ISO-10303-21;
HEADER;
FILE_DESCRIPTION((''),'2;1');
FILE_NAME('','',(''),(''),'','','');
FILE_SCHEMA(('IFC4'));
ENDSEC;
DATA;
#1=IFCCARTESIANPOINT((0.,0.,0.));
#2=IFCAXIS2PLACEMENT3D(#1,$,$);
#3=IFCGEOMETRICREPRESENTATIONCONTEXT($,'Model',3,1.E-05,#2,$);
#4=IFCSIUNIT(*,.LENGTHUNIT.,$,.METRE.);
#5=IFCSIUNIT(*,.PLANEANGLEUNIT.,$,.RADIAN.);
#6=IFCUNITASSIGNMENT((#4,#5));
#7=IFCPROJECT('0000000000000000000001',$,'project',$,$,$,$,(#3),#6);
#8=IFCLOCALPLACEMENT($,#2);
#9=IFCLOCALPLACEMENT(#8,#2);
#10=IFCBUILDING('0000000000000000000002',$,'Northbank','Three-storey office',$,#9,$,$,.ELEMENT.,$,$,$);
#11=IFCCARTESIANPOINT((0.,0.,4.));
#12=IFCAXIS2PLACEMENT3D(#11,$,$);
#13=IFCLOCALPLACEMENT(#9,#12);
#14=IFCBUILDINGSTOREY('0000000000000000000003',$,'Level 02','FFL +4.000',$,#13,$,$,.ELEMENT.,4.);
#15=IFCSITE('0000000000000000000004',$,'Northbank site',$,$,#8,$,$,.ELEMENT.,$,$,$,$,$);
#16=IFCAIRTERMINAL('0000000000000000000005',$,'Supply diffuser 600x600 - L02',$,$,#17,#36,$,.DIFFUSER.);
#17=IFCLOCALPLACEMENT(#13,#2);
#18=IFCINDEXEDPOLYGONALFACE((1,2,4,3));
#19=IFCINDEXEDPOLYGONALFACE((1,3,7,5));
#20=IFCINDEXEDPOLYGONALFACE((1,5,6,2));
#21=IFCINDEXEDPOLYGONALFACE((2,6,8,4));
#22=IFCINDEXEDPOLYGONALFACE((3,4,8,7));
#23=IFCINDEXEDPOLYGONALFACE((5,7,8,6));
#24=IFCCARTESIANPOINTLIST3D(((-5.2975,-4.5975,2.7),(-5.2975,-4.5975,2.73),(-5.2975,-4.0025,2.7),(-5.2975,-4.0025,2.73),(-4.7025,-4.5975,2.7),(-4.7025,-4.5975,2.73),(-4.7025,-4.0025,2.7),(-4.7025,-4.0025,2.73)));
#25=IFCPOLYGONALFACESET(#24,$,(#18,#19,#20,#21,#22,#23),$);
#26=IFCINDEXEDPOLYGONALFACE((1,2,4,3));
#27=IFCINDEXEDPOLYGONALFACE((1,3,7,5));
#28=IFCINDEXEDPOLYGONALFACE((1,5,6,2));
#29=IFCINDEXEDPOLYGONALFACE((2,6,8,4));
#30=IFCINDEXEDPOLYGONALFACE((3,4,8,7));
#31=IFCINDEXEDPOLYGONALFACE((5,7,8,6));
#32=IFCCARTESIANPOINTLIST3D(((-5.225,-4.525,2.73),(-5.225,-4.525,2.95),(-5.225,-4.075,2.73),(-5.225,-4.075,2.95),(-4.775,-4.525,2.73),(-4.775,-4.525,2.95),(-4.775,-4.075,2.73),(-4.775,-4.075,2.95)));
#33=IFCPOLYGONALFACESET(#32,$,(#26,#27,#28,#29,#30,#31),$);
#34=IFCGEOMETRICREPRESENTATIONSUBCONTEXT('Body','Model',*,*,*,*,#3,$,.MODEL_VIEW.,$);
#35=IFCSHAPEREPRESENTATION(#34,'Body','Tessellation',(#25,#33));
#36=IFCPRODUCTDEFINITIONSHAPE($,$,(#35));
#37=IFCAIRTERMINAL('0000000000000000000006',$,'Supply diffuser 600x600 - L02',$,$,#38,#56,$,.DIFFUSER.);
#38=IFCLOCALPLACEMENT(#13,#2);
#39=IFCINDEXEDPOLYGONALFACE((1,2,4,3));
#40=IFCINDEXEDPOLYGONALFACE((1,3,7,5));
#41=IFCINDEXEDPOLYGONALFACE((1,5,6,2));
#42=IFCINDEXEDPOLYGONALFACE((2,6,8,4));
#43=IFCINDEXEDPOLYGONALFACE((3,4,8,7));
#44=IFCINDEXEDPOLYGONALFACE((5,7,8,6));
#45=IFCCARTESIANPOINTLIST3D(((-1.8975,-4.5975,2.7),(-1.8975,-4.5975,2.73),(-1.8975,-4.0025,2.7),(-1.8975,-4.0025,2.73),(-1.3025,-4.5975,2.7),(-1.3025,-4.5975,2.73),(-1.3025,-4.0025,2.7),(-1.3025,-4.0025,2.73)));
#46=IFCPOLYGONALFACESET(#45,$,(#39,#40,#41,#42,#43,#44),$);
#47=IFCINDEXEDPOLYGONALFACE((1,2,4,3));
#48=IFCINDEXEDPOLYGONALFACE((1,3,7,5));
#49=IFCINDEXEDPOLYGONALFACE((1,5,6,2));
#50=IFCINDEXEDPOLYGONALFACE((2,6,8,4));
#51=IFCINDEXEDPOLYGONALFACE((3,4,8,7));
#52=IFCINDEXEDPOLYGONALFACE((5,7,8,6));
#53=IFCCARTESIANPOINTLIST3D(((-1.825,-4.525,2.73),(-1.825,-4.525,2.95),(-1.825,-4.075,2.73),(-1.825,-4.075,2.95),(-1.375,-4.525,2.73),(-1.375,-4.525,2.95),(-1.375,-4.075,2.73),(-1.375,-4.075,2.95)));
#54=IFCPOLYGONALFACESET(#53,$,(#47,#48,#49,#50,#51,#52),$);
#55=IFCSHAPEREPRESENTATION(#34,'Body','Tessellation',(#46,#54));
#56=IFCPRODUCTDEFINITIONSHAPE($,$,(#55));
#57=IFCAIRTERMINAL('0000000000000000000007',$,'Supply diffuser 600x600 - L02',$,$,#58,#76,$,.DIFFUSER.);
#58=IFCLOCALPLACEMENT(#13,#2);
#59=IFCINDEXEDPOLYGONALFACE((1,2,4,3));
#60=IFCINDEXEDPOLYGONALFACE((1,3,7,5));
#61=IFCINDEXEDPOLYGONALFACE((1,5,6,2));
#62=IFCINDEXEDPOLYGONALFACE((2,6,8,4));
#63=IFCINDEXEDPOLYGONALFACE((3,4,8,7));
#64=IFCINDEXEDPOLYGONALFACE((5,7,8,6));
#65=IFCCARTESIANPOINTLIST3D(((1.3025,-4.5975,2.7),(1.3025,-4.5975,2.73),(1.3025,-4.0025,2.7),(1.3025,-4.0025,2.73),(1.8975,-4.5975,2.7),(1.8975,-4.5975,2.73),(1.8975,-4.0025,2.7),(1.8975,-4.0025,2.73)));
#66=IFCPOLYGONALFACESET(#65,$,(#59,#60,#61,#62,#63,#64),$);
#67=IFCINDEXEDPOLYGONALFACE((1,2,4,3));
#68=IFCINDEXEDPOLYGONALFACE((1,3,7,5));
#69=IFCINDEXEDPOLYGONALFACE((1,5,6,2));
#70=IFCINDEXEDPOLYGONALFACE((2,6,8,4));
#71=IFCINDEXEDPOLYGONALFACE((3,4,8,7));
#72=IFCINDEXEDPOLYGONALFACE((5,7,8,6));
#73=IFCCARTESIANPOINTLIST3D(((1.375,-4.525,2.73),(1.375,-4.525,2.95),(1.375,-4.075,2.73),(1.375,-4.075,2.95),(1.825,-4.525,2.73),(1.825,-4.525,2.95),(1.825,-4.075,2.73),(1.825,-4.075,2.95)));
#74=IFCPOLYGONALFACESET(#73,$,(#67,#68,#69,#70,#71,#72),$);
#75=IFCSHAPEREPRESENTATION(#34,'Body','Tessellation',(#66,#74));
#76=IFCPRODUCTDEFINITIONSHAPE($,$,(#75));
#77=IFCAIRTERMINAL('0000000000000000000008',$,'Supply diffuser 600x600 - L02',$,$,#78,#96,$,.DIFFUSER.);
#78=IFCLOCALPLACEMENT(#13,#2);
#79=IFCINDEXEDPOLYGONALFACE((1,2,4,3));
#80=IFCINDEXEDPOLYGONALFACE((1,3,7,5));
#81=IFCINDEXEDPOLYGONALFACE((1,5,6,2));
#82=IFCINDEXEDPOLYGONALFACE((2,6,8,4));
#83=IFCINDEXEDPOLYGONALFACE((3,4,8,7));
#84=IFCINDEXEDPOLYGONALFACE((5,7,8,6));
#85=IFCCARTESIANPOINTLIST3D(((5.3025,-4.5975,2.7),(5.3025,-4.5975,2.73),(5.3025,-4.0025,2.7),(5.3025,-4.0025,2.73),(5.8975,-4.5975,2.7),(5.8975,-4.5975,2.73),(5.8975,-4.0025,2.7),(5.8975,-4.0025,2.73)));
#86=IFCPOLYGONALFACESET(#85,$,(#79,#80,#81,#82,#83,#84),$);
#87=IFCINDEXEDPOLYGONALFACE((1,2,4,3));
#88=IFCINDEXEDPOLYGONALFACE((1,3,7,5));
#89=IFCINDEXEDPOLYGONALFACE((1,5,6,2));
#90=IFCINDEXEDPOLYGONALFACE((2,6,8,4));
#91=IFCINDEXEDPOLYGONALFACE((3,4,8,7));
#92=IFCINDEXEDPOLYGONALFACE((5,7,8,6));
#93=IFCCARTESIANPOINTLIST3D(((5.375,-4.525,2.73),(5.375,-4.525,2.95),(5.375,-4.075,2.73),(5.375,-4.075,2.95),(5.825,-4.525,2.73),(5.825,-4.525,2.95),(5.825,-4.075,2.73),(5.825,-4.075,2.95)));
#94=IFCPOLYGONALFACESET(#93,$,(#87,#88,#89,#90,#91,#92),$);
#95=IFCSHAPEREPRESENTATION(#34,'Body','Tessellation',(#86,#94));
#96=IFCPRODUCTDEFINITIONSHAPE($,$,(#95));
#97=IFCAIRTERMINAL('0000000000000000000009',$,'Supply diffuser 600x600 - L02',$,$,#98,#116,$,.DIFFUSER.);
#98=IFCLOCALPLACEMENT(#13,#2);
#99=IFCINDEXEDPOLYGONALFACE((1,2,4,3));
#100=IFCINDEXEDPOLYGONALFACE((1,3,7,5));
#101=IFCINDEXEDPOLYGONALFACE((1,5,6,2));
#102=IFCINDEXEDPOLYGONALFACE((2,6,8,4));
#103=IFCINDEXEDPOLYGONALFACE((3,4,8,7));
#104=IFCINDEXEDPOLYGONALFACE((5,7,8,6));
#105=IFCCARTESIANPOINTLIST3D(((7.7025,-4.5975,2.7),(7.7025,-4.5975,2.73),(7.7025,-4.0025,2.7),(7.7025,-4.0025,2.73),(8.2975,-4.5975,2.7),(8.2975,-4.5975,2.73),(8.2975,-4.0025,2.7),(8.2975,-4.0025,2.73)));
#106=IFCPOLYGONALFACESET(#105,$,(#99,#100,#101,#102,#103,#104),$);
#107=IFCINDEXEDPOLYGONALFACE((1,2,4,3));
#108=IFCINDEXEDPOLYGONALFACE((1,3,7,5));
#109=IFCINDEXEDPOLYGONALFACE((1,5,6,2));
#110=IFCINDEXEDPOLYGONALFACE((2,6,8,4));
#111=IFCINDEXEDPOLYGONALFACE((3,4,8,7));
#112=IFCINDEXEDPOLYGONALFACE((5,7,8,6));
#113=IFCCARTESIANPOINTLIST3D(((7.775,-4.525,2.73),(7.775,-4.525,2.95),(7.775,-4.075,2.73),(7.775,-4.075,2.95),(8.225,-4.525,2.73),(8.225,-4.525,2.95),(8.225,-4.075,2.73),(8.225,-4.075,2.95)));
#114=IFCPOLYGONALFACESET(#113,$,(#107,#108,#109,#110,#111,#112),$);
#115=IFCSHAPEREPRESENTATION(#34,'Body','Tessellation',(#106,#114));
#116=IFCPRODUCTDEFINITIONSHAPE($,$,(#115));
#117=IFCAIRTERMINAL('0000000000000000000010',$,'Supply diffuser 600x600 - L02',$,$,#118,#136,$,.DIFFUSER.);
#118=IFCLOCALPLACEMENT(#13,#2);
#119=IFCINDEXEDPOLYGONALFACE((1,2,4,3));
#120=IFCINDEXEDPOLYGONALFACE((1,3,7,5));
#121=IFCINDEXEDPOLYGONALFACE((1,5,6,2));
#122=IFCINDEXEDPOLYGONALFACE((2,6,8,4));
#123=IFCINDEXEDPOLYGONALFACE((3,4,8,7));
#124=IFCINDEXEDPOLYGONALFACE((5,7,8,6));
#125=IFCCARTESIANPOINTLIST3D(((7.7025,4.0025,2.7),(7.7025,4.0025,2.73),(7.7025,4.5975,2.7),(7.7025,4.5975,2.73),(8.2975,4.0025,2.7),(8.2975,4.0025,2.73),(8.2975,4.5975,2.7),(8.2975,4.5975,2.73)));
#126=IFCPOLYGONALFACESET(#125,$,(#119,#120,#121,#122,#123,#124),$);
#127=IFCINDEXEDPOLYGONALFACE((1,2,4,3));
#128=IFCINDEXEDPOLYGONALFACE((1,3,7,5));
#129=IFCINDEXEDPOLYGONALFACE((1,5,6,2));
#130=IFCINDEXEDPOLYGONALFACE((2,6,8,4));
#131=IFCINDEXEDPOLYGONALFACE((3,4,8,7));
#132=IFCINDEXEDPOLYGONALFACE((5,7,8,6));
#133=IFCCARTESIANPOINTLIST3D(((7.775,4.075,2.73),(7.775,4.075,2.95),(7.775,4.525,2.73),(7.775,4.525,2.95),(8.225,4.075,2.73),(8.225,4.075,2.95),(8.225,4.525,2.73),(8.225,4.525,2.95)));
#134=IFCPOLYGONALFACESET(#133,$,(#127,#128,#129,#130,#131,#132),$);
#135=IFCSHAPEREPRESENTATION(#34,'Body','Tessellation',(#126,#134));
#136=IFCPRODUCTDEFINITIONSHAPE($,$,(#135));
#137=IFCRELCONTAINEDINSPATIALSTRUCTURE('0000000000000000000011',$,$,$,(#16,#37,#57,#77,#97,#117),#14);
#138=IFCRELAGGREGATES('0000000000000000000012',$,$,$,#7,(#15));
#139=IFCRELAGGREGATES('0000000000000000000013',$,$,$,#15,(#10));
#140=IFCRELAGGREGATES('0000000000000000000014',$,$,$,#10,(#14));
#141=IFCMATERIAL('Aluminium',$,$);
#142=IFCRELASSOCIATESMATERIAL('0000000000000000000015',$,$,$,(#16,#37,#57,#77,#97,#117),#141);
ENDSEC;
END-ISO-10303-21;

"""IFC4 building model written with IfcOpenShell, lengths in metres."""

from ifc_helpers import new_model, si_unit, frame, origin, place, context, subcontext, project, spatial, rectangle, extrude, material, element, save


model = new_model("IFC4")

# Units and contexts
model_context = context("Model", 3, precision=1e-05, world=origin())
body_context = subcontext(model_context, "Body", "Model", "MODEL_VIEW")
ifc_project = project(units=[si_unit("LENGTHUNIT", "METRE"), si_unit("PLANEANGLEUNIT", "RADIAN")], contexts=[model_context])

# Site, building, storey
site_placement = place(None, origin())
site = spatial("IfcSite", under=ifc_project, at=site_placement, Name="Northbank site", CompositionType="ELEMENT")
building_placement = place(site_placement, origin())
building = spatial("IfcBuilding", under=site, at=building_placement, Name="Northbank", Description="Three-storey office", CompositionType="ELEMENT")
storey_placement = place(building_placement, frame((0.0, 0.0, 4.0)))
storey = spatial("IfcBuildingStorey", under=building, at=storey_placement, Name="Level 02", Description="FFL +4.000", CompositionType="ELEMENT", Elevation=4.0)

# Air terminal
ifc_material_1 = material(Name="Aluminium")
air_terminal_1_placement = place(storey_placement, frame((0.0, 0.0, -4.0)))
element("IfcAirTerminal", 1, at=air_terminal_1_placement, inside=storey, material=ifc_material_1, Name="Supply diffuser 600x600 - L02", PredefinedType="DIFFUSER", context=body_context, shape_type="SweptSolid", body=[
    extrude(rectangle(XDim=0.595, YDim=0.595), frame((-5.0, -4.3, 6.7)), (0.0, 0.0, 1.0), 0.03),
    extrude(rectangle(XDim=0.45, YDim=0.45), frame((-5.0, -4.3, 6.73)), (0.0, 0.0, 1.0), 0.22),
])

# Air terminal
air_terminal_2_placement = place(storey_placement, frame((0.0, 0.0, -4.0)))
element("IfcAirTerminal", 2, at=air_terminal_2_placement, inside=storey, material=ifc_material_1, Name="Supply diffuser 600x600 - L02", PredefinedType="DIFFUSER", context=body_context, shape_type="SweptSolid", body=[
    extrude(rectangle(XDim=0.595, YDim=0.595), frame((-1.6, -4.3, 6.7)), (0.0, 0.0, 1.0), 0.03),
    extrude(rectangle(XDim=0.45, YDim=0.45), frame((-1.6, -4.3, 6.73)), (0.0, 0.0, 1.0), 0.22),
])

# Air terminal
air_terminal_3_placement = place(storey_placement, frame((0.0, 0.0, -4.0)))
element("IfcAirTerminal", 3, at=air_terminal_3_placement, inside=storey, material=ifc_material_1, Name="Supply diffuser 600x600 - L02", PredefinedType="DIFFUSER", context=body_context, shape_type="SweptSolid", body=[
    extrude(rectangle(XDim=0.595, YDim=0.595), frame((1.6, -4.3, 6.7)), (0.0, 0.0, 1.0), 0.03),
    extrude(rectangle(XDim=0.45, YDim=0.45), frame((1.6, -4.3, 6.73)), (0.0, 0.0, 1.0), 0.22),
])

# Air terminal
air_terminal_4_placement = place(storey_placement, frame((0.0, 0.0, -4.0)))
element("IfcAirTerminal", 4, at=air_terminal_4_placement, inside=storey, material=ifc_material_1, Name="Supply diffuser 600x600 - L02", PredefinedType="DIFFUSER", context=body_context, shape_type="SweptSolid", body=[
    extrude(rectangle(XDim=0.595, YDim=0.595), frame((5.6, -4.3, 6.7)), (0.0, 0.0, 1.0), 0.03),
    extrude(rectangle(XDim=0.45, YDim=0.45), frame((5.6, -4.3, 6.73)), (0.0, 0.0, 1.0), 0.22),
])

# Air terminal
air_terminal_5_placement = place(storey_placement, frame((0.0, 0.0, -4.0)))
element("IfcAirTerminal", 5, at=air_terminal_5_placement, inside=storey, material=ifc_material_1, Name="Supply diffuser 600x600 - L02", PredefinedType="DIFFUSER", context=body_context, shape_type="SweptSolid", body=[
    extrude(rectangle(XDim=0.595, YDim=0.595), frame((8.0, -4.3, 6.7)), (0.0, 0.0, 1.0), 0.03),
    extrude(rectangle(XDim=0.45, YDim=0.45), frame((8.0, -4.3, 6.73)), (0.0, 0.0, 1.0), 0.22),
])

# Air terminal
air_terminal_6_placement = place(storey_placement, frame((0.0, 0.0, -4.0)))
element("IfcAirTerminal", 6, at=air_terminal_6_placement, inside=storey, material=ifc_material_1, Name="Supply diffuser 600x600 - L02", PredefinedType="DIFFUSER", context=body_context, shape_type="SweptSolid", body=[
    extrude(rectangle(XDim=0.595, YDim=0.595), frame((8.0, 4.3, 6.7)), (0.0, 0.0, 1.0), 0.03),
    extrude(rectangle(XDim=0.45, YDim=0.45), frame((8.0, 4.3, 6.73)), (0.0, 0.0, 1.0), 0.22),
])

save(model, "model.ifc")
